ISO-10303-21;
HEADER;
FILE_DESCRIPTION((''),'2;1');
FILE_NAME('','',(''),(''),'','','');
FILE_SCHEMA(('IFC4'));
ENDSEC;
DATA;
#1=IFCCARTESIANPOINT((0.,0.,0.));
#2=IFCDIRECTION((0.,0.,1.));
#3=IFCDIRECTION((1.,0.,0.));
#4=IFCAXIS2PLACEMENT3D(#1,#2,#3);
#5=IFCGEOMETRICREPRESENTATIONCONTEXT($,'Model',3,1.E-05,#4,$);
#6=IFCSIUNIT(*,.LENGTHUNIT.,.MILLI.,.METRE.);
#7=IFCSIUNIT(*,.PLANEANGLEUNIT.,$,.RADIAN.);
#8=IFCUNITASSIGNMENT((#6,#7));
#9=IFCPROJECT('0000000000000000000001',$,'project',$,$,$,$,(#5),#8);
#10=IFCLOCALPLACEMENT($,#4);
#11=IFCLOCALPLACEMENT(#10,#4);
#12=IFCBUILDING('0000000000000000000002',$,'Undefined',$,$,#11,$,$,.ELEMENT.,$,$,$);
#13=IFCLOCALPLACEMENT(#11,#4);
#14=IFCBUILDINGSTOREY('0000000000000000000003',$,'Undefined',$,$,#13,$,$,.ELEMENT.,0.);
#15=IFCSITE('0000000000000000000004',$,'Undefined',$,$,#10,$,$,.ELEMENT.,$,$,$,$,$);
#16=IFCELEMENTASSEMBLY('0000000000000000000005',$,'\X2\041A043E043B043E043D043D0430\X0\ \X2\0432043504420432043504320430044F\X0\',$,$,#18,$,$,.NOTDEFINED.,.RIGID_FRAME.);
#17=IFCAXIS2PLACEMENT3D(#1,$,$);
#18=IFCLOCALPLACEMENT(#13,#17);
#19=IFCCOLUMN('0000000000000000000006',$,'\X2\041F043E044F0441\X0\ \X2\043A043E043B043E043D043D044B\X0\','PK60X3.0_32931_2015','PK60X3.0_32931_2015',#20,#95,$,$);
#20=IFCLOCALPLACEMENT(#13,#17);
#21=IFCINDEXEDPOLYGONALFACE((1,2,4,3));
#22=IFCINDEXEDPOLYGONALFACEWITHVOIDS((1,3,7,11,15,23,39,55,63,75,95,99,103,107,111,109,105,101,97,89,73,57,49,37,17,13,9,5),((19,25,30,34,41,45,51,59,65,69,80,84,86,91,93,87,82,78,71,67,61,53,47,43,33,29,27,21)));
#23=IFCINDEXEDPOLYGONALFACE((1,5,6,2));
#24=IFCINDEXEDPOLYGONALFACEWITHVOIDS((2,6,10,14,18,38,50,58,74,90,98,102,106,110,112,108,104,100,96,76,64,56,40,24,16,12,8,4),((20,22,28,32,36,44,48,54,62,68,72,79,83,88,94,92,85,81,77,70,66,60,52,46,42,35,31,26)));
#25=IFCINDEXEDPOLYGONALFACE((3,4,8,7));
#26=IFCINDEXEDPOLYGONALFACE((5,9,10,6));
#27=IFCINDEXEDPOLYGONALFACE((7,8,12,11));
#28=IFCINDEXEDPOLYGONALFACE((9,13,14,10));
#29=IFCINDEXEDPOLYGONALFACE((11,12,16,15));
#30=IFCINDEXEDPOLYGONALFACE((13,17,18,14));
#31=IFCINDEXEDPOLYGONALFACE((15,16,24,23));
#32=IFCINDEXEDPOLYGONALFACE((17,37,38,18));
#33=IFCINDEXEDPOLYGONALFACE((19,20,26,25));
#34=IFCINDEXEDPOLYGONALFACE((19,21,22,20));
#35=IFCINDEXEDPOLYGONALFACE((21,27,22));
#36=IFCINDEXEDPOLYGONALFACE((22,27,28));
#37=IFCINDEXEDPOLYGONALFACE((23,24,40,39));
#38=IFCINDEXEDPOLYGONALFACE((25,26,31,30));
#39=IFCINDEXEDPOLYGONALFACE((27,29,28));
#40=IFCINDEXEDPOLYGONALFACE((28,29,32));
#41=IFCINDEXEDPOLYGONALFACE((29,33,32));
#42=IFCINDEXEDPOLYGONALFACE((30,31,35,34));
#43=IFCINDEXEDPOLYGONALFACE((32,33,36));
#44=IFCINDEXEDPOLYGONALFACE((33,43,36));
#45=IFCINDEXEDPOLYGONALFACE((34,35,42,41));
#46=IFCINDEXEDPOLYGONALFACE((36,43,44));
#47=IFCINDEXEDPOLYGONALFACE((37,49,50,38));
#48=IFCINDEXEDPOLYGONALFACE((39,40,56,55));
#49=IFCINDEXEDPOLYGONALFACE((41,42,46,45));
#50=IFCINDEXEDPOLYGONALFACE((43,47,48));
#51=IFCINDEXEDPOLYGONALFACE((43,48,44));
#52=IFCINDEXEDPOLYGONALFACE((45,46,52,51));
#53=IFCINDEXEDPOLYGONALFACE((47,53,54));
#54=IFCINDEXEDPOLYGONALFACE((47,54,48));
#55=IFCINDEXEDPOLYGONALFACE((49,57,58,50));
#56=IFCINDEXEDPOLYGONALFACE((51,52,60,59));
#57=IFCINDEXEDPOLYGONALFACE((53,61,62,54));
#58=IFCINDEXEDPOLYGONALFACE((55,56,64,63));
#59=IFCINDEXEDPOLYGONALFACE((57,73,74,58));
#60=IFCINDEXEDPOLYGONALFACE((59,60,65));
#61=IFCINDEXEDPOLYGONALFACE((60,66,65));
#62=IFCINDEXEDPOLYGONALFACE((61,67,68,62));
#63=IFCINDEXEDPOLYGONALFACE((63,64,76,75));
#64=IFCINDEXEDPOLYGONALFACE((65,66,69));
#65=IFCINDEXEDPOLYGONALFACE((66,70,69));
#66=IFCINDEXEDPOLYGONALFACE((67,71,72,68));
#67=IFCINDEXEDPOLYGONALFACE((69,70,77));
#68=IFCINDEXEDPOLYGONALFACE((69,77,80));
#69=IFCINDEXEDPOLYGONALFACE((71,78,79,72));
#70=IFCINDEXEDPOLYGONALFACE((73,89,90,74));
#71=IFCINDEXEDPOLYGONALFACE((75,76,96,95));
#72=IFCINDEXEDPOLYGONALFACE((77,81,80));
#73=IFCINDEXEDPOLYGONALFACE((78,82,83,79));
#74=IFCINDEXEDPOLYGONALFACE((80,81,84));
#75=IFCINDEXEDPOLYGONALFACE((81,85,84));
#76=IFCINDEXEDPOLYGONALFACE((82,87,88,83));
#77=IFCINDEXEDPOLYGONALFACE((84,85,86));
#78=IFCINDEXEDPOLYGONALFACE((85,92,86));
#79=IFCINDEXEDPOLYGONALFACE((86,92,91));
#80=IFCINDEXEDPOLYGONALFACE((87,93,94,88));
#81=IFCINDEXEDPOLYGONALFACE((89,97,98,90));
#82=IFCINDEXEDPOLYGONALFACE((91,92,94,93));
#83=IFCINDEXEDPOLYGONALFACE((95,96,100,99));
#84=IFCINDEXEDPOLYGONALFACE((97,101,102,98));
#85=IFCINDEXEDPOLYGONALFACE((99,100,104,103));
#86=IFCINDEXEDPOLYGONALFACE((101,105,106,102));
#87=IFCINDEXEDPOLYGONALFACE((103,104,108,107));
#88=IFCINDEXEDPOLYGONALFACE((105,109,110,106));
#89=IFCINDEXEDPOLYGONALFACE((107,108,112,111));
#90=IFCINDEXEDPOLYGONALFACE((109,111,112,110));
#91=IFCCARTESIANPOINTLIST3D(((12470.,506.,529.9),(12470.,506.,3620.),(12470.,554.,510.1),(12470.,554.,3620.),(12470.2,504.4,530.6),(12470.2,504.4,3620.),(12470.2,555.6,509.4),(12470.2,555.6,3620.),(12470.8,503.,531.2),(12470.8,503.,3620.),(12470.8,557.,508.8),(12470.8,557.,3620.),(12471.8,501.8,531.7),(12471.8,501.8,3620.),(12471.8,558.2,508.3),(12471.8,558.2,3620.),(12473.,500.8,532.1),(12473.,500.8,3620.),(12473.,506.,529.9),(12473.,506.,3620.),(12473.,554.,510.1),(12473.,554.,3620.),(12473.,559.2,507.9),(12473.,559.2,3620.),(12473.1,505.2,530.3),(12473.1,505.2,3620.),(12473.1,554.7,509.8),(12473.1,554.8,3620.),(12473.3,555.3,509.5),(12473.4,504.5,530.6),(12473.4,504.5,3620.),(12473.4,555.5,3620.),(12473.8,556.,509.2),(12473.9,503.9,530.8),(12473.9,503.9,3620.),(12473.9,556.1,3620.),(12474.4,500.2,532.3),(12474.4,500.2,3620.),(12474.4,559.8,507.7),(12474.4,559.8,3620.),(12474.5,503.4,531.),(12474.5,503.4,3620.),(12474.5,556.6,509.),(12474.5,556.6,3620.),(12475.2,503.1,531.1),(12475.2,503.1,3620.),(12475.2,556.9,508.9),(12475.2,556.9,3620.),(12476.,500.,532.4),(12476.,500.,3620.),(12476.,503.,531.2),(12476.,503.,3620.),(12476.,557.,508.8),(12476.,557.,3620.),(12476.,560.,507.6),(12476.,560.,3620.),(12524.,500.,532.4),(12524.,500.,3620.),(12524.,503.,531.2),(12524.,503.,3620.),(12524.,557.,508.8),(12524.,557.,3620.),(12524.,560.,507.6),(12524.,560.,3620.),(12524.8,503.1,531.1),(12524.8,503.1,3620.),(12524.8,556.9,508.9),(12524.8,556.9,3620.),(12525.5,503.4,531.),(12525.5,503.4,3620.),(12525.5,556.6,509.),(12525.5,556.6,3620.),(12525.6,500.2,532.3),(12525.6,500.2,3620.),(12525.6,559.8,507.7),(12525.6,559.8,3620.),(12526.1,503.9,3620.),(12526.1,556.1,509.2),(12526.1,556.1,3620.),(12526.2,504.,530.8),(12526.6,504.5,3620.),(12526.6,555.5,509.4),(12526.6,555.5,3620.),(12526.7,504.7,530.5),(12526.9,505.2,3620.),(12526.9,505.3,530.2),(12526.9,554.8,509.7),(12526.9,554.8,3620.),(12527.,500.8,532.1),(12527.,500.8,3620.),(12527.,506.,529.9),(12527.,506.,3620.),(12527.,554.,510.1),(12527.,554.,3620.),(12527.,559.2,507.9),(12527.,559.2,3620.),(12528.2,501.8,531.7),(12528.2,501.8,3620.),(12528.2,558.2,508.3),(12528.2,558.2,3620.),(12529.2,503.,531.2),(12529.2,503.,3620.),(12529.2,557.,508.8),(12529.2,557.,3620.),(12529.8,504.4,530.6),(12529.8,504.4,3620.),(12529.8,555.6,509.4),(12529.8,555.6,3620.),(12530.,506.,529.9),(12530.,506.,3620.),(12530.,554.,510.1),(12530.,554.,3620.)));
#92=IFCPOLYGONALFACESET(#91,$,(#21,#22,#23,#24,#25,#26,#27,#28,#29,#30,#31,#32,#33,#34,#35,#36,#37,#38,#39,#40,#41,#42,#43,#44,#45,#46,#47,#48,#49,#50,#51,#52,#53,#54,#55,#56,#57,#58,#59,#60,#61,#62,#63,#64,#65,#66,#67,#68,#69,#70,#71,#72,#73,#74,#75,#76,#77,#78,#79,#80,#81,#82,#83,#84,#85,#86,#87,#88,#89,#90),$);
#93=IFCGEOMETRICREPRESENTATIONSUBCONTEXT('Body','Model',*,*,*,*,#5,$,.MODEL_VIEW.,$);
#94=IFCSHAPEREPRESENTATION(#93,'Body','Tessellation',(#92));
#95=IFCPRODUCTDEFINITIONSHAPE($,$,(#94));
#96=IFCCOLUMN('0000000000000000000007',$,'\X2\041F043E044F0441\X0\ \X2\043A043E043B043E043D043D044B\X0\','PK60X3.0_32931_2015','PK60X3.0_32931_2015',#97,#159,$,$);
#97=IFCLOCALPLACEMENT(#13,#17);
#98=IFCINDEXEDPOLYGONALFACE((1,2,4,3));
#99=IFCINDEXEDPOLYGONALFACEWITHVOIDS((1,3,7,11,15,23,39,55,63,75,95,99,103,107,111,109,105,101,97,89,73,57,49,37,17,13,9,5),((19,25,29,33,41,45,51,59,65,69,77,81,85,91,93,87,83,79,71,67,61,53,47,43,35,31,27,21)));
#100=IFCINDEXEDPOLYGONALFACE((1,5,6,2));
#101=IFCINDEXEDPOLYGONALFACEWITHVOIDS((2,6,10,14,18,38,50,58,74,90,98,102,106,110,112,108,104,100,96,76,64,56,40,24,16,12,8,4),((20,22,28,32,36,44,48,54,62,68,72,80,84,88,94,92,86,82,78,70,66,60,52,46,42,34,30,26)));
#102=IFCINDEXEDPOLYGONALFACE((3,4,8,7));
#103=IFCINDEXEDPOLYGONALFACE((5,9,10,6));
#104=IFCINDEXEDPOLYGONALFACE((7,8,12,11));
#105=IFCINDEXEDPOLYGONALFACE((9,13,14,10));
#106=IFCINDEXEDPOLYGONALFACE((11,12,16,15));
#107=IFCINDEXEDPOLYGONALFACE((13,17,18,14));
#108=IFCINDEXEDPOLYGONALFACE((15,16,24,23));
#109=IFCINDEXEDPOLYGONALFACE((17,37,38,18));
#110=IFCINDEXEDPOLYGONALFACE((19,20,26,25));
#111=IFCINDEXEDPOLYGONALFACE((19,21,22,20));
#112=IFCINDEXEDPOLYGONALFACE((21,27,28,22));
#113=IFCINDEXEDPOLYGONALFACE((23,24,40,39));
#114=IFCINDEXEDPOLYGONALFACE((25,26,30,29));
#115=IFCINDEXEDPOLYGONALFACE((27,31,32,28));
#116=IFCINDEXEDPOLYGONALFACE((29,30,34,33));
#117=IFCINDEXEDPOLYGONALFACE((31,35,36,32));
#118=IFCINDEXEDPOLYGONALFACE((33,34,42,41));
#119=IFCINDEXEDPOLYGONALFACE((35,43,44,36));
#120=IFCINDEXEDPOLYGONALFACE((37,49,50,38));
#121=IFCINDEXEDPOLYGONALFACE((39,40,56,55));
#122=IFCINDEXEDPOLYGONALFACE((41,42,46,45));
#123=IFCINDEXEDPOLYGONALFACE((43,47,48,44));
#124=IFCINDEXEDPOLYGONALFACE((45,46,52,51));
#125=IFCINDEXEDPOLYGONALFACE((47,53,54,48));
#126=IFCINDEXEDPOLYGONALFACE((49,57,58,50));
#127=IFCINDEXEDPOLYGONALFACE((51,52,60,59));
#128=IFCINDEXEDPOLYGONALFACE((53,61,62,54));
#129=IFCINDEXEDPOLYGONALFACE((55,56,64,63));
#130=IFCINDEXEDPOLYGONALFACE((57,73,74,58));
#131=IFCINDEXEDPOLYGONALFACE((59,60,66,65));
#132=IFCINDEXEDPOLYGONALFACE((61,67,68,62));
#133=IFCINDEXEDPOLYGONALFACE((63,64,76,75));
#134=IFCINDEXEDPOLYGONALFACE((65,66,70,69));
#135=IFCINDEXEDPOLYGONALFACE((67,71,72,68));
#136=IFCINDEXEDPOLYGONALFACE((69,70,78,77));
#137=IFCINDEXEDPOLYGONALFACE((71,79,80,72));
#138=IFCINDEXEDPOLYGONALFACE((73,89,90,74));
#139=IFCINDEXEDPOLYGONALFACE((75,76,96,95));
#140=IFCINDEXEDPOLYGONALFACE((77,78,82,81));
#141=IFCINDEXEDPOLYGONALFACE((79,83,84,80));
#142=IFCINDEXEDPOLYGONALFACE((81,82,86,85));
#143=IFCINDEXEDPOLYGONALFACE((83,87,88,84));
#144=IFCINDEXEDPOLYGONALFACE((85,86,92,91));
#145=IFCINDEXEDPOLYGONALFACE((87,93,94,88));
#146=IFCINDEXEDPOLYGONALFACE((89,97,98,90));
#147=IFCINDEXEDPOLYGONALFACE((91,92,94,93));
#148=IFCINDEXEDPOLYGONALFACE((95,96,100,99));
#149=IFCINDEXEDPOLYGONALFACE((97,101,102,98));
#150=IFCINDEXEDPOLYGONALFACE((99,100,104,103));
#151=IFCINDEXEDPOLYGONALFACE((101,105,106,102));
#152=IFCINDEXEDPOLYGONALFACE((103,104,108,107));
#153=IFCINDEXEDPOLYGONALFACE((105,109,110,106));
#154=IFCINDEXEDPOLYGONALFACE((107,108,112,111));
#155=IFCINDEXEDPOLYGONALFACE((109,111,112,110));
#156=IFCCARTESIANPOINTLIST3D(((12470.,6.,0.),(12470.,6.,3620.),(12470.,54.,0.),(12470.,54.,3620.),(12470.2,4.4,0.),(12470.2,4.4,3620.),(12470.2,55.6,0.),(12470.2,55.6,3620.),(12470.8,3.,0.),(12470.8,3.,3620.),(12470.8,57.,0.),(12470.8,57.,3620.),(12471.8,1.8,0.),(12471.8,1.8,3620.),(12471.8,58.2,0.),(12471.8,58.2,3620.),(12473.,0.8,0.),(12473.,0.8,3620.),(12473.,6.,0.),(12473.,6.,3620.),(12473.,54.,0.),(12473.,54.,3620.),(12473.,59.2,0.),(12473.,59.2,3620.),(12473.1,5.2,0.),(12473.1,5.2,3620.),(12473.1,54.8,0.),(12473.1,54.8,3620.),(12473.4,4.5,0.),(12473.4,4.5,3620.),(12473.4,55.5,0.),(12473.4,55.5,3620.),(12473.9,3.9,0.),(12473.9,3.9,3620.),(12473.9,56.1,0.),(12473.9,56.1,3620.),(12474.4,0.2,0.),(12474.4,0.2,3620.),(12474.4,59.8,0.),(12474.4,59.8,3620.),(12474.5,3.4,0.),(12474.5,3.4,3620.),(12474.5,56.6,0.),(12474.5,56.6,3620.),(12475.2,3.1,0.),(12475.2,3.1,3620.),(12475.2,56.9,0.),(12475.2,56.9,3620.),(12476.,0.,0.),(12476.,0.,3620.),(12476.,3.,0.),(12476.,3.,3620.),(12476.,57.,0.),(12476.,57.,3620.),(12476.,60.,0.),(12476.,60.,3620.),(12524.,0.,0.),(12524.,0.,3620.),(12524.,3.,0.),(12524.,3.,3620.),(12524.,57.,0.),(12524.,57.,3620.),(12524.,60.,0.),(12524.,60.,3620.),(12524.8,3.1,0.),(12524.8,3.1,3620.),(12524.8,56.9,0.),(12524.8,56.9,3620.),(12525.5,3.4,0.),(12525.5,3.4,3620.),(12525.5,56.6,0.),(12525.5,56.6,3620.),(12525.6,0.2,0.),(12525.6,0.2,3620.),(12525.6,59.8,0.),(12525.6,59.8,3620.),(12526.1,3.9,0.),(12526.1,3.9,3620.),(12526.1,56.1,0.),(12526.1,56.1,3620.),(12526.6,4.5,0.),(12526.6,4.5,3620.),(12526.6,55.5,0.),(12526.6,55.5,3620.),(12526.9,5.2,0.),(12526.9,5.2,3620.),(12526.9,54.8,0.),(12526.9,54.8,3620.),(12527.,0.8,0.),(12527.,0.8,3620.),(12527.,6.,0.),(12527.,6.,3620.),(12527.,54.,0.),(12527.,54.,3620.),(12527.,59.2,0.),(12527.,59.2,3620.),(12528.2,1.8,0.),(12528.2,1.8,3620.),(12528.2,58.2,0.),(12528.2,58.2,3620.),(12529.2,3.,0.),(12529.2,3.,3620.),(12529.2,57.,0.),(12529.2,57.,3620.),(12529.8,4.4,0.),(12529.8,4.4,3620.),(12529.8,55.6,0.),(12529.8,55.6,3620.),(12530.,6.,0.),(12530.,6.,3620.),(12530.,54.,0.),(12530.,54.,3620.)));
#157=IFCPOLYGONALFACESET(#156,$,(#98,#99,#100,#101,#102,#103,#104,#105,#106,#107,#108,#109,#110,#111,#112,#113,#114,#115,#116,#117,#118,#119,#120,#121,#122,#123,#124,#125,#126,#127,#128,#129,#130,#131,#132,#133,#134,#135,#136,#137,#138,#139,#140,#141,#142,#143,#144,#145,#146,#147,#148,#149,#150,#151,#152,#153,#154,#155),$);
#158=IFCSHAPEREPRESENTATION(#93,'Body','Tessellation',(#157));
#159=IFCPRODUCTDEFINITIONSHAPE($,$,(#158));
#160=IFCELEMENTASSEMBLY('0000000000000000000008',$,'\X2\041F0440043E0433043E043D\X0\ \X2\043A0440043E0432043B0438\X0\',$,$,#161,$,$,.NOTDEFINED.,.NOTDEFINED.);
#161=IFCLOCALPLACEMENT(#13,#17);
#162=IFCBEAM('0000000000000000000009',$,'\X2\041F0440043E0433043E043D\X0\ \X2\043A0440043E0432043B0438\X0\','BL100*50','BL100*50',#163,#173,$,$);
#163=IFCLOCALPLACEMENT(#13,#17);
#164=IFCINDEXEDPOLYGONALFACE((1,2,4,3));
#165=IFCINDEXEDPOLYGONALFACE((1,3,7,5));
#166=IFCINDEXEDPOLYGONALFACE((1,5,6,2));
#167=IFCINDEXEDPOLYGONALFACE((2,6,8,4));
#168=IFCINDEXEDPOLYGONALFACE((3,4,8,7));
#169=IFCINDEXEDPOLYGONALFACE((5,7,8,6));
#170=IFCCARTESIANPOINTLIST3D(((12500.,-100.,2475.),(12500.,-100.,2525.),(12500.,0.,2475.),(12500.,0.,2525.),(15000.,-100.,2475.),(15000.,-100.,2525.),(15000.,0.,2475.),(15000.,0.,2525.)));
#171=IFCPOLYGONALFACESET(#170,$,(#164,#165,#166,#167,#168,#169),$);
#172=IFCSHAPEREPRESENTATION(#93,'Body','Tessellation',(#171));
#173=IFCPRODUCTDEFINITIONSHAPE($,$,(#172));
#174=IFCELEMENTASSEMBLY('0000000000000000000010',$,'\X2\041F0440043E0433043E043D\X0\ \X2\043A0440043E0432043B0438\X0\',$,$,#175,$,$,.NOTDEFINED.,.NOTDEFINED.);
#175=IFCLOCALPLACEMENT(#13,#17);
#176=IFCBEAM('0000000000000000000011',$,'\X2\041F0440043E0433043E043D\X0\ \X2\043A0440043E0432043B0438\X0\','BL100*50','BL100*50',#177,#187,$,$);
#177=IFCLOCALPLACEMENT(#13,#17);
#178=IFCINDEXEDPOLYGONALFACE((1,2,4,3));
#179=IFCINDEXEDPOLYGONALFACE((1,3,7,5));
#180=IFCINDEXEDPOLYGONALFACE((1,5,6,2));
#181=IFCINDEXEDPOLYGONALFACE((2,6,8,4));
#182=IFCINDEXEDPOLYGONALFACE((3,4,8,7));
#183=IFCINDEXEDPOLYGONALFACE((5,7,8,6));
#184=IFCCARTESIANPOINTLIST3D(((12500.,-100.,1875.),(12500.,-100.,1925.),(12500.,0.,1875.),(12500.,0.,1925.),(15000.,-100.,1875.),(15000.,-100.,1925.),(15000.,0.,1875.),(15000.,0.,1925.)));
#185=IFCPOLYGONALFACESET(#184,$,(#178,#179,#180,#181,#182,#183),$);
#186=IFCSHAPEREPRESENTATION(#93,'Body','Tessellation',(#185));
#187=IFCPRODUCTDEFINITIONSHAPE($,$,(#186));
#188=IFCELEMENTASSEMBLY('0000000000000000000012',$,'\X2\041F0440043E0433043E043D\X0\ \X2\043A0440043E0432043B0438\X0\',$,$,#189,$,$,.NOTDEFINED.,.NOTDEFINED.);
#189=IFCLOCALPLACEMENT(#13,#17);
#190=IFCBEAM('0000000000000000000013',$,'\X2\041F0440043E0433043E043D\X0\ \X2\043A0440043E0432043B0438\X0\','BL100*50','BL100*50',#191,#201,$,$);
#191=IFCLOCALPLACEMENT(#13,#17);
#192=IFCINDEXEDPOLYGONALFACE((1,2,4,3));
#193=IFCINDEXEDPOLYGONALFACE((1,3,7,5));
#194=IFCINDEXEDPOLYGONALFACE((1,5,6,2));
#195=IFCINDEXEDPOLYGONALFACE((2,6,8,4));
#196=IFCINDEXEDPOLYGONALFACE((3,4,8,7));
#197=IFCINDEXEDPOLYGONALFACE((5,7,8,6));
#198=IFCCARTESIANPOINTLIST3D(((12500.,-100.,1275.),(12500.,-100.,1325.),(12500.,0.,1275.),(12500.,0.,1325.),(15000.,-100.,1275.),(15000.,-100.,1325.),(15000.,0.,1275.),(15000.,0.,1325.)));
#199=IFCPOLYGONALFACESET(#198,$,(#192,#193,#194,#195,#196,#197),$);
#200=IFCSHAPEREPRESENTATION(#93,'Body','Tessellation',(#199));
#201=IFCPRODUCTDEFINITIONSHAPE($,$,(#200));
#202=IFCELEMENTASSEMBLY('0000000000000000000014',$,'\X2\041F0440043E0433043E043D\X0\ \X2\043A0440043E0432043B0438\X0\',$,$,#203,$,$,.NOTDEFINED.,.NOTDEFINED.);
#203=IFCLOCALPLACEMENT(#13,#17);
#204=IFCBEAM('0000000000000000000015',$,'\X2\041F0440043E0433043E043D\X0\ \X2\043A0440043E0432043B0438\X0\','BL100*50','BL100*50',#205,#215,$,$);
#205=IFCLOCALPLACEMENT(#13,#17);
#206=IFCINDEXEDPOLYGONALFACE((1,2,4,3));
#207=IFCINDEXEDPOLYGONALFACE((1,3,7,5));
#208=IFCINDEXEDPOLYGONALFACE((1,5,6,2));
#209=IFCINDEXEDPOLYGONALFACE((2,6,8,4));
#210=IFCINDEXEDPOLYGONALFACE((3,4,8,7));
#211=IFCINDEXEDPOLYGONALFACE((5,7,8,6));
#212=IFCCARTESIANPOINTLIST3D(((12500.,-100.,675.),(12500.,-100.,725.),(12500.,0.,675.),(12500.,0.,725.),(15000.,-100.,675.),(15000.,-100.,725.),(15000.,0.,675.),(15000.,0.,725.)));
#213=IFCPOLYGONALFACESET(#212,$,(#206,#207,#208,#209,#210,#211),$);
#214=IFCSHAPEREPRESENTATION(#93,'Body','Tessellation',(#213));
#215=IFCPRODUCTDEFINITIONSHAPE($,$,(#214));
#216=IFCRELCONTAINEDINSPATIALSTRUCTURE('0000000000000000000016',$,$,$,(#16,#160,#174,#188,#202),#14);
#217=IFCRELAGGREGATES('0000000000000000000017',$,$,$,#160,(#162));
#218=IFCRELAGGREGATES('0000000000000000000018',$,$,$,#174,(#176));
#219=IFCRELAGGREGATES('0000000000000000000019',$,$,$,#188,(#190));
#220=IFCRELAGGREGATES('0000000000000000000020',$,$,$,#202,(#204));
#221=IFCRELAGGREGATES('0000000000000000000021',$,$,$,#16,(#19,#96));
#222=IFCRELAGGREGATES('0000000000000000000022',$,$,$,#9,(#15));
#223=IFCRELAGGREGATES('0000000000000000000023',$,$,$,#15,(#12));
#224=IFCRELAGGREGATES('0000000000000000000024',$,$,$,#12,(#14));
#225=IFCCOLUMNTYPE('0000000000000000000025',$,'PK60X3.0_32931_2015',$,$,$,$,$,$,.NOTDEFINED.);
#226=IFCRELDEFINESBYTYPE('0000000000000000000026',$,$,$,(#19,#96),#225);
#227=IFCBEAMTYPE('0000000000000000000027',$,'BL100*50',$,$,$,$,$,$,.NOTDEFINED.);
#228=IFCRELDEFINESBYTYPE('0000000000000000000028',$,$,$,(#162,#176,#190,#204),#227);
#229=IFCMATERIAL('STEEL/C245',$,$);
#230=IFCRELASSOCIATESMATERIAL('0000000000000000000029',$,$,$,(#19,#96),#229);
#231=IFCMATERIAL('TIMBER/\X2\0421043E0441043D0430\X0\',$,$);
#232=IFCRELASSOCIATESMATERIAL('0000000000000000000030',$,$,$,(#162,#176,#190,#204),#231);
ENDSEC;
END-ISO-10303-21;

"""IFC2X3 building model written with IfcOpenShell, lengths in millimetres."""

from ifc_helpers import new_model, si_unit, frame, origin_with_axes, origin_2d_with_axis, place, context, subcontext, project, spatial, rectangle, hollow_rectangle, extrude, clip, halfspace, material, type_object, element, aggregate, save


model = new_model("IFC2X3")

# Units and contexts
model_context = context("Model", 3, precision=1e-05, world=origin_with_axes())
body_context = subcontext(model_context, "Body", "Model", "MODEL_VIEW")
ifc_project = project(units=[si_unit("LENGTHUNIT", "METRE", prefix="MILLI"), si_unit("PLANEANGLEUNIT", "RADIAN")], contexts=[model_context])

# Site, building, storey
site_placement = place(None, origin_with_axes())
site = spatial("IfcSite", under=ifc_project, at=site_placement, Name="Undefined", CompositionType="ELEMENT")
building_placement = place(site_placement, origin_with_axes())
building = spatial("IfcBuilding", under=site, at=building_placement, Name="Undefined", CompositionType="ELEMENT")
storey_placement = place(building_placement, origin_with_axes())
storey = spatial("IfcBuildingStorey", under=building, at=storey_placement, Name="Undefined", CompositionType="ELEMENT", Elevation=0.0)

# Element assembly, columns
ifc_material_1 = material(Name="STEEL/C245")
column_type = type_object("IfcColumnType", Name="PK60X3.0_32931_2015", PredefinedType="NOTDEFINED")
assembly_1_placement = place(storey_placement, origin_with_axes())
assembly_1 = element("IfcElementAssembly", 1, at=assembly_1_placement, inside=storey, Name="Колонна ветвевая", AssemblyPlace="NOTDEFINED", PredefinedType="RIGID_FRAME")
column_1_placement = place(assembly_1_placement, frame((12500.0, 530.0, 0.0), z_axis=(0.0, 0.0, 1.0), x_axis=(-1.0, 0.0, 0.0)))
column_1 = element("IfcColumn", 2, at=column_1_placement, type_object=column_type, material=ifc_material_1, Name="Пояс колонны", Description="PK60X3.0_32931_2015", ObjectType="PK60X3.0_32931_2015", context=body_context, shape_type="Clipping", body=[
    clip(extrude(hollow_rectangle(XDim=60.0, YDim=60.0, WallThickness=3.0, InnerFilletRadius=3.0, OuterFilletRadius=6.0, at=origin_2d_with_axis()), frame((0.0, 0.0, 3620.0), z_axis=(0.0, 0.0, -1.0), x_axis=(0.0, 1.0, 0.0)), (0.0, 0.0, 1.0), 3112.6), halfspace(frame((0.0, 30.0, 532.4), z_axis=(0.0, -0.382683, 0.92388), x_axis=(1.0, 0.0, 0.0)), True)),
])
column_2_placement = place(assembly_1_placement, frame((12500.0, 30.0, 0.0), z_axis=(0.0, 0.0, 1.0), x_axis=(-1.0, 0.0, 0.0)))
column_2 = element("IfcColumn", 3, at=column_2_placement, type_object=column_type, material=ifc_material_1, Name="Пояс колонны", Description="PK60X3.0_32931_2015", ObjectType="PK60X3.0_32931_2015", context=body_context, shape_type="SweptSolid", body=[
    extrude(hollow_rectangle(XDim=60.0, YDim=60.0, WallThickness=3.0, InnerFilletRadius=3.0, OuterFilletRadius=6.0, at=origin_2d_with_axis()), frame((0.0, 0.0, 3620.0), z_axis=(0.0, 0.0, -1.0), x_axis=(0.0, 1.0, 0.0)), (0.0, 0.0, 1.0), 3620.0),
])

# Element assemblies, beams
assembly_2_placement = place(storey_placement, origin_with_axes())
assembly_2 = element("IfcElementAssembly", 4, at=assembly_2_placement, inside=storey, Name="Прогон кровли", AssemblyPlace="NOTDEFINED", PredefinedType="NOTDEFINED")
ifc_material_2 = material(Name="TIMBER/Сосна")
beam_type_1 = type_object("IfcBeamType", Name="BL100*50", PredefinedType="NOTDEFINED")
beam_1_placement = place(assembly_2_placement, frame((12500.0, -50.0, 2500.0), z_axis=(0.0, -1.0, 0.0), x_axis=(1.0, 0.0, 0.0)))
beam_1 = element("IfcBeam", 5, at=beam_1_placement, type_object=beam_type_1, material=ifc_material_2, Name="Прогон кровли", Description="BL100*50", ObjectType="BL100*50", context=body_context, shape_type="SweptSolid", body=[
    extrude(rectangle(XDim=50.0, YDim=100.0, at=origin_2d_with_axis()), frame((2500.0, 0.0, 0.0), z_axis=(-1.0, 0.0, 0.0), x_axis=(0.0, -1.0, 0.0)), (0.0, 0.0, 1.0), 2500.0),
])
aggregate(assembly_2, [beam_1])
assembly_3_placement = place(storey_placement, origin_with_axes())
assembly_3 = element("IfcElementAssembly", 6, at=assembly_3_placement, inside=storey, Name="Прогон кровли", AssemblyPlace="NOTDEFINED", PredefinedType="NOTDEFINED")
beam_2_placement = place(assembly_3_placement, frame((12500.0, -50.0, 1900.0), z_axis=(0.0, -1.0, 0.0), x_axis=(1.0, 0.0, 0.0)))
beam_2 = element("IfcBeam", 7, at=beam_2_placement, type_object=beam_type_1, material=ifc_material_2, Name="Прогон кровли", Description="BL100*50", ObjectType="BL100*50", context=body_context, shape_type="SweptSolid", body=[
    extrude(rectangle(XDim=50.0, YDim=100.0, at=origin_2d_with_axis()), frame((2500.0, 0.0, 0.0), z_axis=(-1.0, 0.0, 0.0), x_axis=(0.0, -1.0, 0.0)), (0.0, 0.0, 1.0), 2500.0),
])
aggregate(assembly_3, [beam_2])
assembly_4_placement = place(storey_placement, origin_with_axes())
assembly_4 = element("IfcElementAssembly", 8, at=assembly_4_placement, inside=storey, Name="Прогон кровли", AssemblyPlace="NOTDEFINED", PredefinedType="NOTDEFINED")
beam_3_placement = place(assembly_4_placement, frame((12500.0, -50.0, 1300.0), z_axis=(0.0, -1.0, 0.0), x_axis=(1.0, 0.0, 0.0)))
beam_3 = element("IfcBeam", 9, at=beam_3_placement, type_object=beam_type_1, material=ifc_material_2, Name="Прогон кровли", Description="BL100*50", ObjectType="BL100*50", context=body_context, shape_type="SweptSolid", body=[
    extrude(rectangle(XDim=50.0, YDim=100.0, at=origin_2d_with_axis()), frame((2500.0, 0.0, 0.0), z_axis=(-1.0, 0.0, 0.0), x_axis=(0.0, -1.0, 0.0)), (0.0, 0.0, 1.0), 2500.0),
])
aggregate(assembly_4, [beam_3])
assembly_5_placement = place(storey_placement, origin_with_axes())
assembly_5 = element("IfcElementAssembly", 10, at=assembly_5_placement, inside=storey, Name="Прогон кровли", AssemblyPlace="NOTDEFINED", PredefinedType="NOTDEFINED")
beam_4_placement = place(assembly_5_placement, frame((12500.0, -50.0, 700.0), z_axis=(0.0, -1.0, 0.0), x_axis=(1.0, 0.0, 0.0)))
beam_4 = element("IfcBeam", 11, at=beam_4_placement, type_object=beam_type_1, material=ifc_material_2, Name="Прогон кровли", Description="BL100*50", ObjectType="BL100*50", context=body_context, shape_type="SweptSolid", body=[
    extrude(rectangle(XDim=50.0, YDim=100.0, at=origin_2d_with_axis()), frame((2500.0, 0.0, 0.0), z_axis=(-1.0, 0.0, 0.0), x_axis=(0.0, -1.0, 0.0)), (0.0, 0.0, 1.0), 2500.0),
])
aggregate(assembly_5, [beam_4])

aggregate(assembly_1, [column_1, column_2])

save(model, "model.ifc")
